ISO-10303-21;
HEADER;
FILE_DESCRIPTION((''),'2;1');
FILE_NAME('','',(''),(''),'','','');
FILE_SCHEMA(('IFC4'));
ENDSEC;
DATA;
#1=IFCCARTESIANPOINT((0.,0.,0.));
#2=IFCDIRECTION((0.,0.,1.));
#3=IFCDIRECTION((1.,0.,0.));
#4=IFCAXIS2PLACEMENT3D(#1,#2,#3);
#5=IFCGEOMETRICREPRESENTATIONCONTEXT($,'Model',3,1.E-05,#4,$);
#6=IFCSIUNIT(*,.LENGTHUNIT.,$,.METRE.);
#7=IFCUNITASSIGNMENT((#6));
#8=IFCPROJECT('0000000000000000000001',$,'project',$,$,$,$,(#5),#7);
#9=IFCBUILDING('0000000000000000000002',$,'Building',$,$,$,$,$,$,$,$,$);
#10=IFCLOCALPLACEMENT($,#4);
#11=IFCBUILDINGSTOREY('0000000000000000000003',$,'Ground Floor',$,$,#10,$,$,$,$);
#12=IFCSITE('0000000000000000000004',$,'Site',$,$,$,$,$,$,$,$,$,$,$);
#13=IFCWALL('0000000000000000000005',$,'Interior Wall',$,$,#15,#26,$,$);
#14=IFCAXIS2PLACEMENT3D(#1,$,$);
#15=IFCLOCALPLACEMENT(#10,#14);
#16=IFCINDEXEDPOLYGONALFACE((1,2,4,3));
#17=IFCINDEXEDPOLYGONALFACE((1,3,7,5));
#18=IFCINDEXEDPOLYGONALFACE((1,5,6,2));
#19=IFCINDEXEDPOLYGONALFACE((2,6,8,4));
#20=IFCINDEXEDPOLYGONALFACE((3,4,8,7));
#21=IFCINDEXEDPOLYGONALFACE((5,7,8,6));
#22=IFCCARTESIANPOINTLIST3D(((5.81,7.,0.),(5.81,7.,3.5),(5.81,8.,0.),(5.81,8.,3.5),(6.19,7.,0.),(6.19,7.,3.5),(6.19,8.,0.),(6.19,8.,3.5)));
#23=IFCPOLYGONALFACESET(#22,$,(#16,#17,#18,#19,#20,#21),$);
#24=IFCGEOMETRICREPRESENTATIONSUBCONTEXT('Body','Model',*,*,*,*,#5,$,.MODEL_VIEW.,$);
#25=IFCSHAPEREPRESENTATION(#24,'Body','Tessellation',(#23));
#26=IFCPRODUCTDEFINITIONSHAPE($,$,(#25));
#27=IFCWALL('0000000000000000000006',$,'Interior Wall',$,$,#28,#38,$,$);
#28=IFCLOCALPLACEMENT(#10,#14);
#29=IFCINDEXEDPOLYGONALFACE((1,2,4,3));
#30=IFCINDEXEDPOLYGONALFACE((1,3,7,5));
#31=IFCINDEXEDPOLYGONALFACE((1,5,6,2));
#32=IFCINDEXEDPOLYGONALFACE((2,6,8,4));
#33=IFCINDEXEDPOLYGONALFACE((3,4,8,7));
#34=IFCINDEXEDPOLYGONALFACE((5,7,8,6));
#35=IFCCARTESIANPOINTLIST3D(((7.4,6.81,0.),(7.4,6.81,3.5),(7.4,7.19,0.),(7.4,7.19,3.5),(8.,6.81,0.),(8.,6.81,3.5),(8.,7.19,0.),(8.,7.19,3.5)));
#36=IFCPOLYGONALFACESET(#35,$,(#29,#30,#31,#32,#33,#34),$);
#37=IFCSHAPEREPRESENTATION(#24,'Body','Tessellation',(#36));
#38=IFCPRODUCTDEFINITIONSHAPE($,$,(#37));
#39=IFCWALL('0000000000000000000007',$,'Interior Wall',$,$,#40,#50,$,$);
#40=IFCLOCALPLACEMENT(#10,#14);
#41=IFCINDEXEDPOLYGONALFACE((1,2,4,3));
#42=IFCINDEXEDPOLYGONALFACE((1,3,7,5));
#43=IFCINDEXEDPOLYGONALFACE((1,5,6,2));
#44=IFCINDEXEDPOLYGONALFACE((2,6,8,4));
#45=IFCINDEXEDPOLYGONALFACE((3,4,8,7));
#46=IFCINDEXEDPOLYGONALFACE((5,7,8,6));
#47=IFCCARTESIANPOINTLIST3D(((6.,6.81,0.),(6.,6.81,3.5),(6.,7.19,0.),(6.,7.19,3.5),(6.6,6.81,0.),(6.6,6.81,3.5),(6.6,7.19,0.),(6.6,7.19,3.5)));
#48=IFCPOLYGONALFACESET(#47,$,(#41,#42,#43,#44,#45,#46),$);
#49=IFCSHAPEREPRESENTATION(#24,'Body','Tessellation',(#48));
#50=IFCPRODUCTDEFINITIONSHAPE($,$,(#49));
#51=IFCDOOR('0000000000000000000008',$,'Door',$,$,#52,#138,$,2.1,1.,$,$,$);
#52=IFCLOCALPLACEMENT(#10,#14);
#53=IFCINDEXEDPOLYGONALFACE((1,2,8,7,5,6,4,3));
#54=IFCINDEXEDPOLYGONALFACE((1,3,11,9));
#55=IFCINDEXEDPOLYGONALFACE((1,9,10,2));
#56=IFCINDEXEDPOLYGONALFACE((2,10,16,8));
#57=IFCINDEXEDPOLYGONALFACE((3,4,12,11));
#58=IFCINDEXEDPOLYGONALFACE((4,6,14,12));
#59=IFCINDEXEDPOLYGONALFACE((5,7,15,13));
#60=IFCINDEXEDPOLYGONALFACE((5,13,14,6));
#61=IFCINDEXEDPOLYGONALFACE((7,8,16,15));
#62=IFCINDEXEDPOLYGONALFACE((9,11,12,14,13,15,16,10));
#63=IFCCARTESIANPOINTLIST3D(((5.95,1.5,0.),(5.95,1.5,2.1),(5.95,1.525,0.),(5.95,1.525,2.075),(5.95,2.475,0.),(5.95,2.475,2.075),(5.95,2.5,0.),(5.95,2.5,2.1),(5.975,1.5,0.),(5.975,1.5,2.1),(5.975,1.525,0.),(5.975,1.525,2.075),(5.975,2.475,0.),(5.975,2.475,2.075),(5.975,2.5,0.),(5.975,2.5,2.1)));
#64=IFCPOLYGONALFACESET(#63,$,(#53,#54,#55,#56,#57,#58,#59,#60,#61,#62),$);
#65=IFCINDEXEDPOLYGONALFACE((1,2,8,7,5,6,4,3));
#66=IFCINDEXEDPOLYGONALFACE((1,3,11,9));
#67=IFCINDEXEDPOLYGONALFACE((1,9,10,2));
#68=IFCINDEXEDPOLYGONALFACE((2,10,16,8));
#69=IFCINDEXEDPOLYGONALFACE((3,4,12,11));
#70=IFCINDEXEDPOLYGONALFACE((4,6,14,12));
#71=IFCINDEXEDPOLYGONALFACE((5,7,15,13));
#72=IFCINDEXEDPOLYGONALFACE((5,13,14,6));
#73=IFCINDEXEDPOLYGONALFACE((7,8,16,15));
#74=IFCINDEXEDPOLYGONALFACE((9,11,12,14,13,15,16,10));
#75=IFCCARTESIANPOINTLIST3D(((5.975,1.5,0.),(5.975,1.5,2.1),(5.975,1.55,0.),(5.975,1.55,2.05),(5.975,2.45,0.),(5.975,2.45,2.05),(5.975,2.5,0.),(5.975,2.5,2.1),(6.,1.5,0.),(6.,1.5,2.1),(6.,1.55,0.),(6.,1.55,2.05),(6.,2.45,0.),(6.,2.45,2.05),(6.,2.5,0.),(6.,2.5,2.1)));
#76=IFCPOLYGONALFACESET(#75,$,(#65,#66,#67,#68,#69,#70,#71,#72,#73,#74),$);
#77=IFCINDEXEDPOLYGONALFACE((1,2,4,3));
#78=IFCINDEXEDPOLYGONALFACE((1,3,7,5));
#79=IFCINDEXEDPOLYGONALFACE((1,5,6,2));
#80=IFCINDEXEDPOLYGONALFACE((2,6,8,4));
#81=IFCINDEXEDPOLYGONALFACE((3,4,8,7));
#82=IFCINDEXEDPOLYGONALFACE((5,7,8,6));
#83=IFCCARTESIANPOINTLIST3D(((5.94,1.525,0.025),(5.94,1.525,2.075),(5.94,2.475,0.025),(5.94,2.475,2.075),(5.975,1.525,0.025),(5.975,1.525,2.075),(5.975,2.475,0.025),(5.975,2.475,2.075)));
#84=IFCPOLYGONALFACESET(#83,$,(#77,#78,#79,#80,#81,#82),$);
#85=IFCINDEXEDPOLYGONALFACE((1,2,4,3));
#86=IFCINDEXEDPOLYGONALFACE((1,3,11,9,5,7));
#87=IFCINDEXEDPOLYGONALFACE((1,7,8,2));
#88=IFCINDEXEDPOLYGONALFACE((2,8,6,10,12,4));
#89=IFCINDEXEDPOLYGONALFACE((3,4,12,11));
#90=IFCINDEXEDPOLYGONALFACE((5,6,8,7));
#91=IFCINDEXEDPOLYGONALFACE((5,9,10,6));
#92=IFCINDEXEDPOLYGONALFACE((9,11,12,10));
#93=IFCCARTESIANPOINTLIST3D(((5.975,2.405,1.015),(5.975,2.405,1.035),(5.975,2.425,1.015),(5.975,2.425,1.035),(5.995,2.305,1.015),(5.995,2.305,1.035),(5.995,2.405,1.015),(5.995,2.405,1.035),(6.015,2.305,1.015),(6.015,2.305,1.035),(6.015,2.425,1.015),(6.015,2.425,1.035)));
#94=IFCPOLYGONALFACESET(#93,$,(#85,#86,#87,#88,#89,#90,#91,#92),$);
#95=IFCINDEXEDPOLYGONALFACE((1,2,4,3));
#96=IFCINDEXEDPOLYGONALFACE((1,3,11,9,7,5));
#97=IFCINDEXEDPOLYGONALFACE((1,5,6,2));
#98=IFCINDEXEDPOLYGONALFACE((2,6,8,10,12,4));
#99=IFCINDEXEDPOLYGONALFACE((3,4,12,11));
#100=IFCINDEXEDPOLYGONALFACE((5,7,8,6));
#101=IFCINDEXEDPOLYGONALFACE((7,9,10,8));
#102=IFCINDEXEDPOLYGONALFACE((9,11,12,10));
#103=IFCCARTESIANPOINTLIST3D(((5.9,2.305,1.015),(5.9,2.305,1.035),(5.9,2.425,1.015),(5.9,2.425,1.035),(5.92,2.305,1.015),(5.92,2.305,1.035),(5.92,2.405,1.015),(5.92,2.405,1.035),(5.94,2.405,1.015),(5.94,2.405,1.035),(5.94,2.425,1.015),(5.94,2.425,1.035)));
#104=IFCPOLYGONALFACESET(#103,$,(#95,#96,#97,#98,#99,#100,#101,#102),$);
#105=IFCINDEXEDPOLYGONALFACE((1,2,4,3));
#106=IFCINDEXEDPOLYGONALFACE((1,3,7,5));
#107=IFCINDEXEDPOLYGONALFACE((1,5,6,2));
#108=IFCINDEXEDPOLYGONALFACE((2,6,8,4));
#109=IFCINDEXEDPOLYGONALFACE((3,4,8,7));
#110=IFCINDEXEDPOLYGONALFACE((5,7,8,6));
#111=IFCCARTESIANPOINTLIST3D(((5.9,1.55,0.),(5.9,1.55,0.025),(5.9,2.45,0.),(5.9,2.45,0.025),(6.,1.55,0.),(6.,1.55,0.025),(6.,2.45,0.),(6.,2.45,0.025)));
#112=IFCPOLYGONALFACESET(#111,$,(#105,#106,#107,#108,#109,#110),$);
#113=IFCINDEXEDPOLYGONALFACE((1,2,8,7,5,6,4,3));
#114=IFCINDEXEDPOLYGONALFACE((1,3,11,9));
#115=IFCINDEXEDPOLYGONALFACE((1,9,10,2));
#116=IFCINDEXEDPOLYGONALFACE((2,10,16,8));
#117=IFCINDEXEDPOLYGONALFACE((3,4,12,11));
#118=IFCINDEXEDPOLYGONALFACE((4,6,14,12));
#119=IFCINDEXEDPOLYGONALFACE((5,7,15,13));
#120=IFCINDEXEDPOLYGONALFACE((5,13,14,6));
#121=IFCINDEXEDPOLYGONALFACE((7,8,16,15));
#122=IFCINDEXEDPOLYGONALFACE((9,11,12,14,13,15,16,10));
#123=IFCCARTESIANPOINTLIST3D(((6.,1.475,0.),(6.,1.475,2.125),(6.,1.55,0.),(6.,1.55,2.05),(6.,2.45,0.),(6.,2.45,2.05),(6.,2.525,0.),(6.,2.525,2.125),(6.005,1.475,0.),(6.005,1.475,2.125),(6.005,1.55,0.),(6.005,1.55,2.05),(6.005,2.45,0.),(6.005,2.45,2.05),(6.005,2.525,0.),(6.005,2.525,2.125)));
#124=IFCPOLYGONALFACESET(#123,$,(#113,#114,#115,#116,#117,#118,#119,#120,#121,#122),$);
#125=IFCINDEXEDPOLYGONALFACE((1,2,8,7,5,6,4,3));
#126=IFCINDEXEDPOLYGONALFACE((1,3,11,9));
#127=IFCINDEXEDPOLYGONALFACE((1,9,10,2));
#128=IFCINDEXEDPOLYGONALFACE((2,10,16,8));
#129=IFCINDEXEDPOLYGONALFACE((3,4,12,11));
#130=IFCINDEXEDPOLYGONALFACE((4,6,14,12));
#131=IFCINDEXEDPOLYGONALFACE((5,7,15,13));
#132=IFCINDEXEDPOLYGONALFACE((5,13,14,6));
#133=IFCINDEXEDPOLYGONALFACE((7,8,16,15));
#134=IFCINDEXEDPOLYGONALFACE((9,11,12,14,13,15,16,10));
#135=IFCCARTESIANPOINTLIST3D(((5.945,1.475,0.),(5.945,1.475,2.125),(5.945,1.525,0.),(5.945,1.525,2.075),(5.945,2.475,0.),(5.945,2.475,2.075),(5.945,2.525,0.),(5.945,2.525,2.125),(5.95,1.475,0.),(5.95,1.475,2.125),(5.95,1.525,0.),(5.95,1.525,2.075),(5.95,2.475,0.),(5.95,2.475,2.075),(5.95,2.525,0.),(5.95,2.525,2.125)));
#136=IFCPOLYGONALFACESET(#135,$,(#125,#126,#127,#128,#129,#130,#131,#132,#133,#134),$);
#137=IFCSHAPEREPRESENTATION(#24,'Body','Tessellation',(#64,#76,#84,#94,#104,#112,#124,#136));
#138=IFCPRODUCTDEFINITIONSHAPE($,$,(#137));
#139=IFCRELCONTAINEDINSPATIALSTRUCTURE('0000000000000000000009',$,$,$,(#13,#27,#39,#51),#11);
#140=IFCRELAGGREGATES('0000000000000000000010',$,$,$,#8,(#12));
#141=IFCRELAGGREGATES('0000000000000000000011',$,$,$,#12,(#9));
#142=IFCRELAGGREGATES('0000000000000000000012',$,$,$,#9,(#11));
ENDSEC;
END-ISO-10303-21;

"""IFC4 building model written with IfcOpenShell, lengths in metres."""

from ifc_helpers import new_model, si_unit, frame, origin_with_axes, place, context, subcontext, project, spatial, line, indexed_curve, outline, extrude, element, save


model = new_model("IFC4")

# Units and contexts
model_context = context("Model", 3, precision=1e-05, world=origin_with_axes())
body_context = subcontext(model_context, "Body", "Model", "MODEL_VIEW")
ifc_project = project(units=[si_unit("LENGTHUNIT", "METRE")], contexts=[model_context])

# Site, building, storey
site = spatial("IfcSite", under=ifc_project, Name="Site")
building = spatial("IfcBuilding", under=site, Name="Building")
storey_placement = place(None, origin_with_axes())
storey = spatial("IfcBuildingStorey", under=building, at=storey_placement, Name="Ground Floor")

# Walls
wall_1_placement = place(storey_placement, frame((6.0, 7.0, 0.0), z_axis=(0.0, 0.0, 1.0), x_axis=(0.0, 1.0, 0.0)))
element("IfcWall", 1, at=wall_1_placement, inside=storey, Name="Interior Wall", context=body_context, shape_type="SweptSolid", body=[
    extrude(outline(indexed_curve([(0.0, 0.0), (0.0, 0.38), (1.0, 0.38), (1.0, 0.0), (0.0, 0.0)], self_intersect=False)), frame((0.0, -0.19, 0.0), z_axis=(0.0, 0.0, 1.0), x_axis=(1.0, 0.0, 0.0)), (0.0, 0.0, 1.0), 3.5),
])
for number, where, z_axis, x_axis, name in (
    (2, (8.0, 7.0, 0.0), (0.0, 0.0, 1.0), (-1.0, 0.0, 0.0), "Interior Wall"),
    (3, (6.6, 7.0, 0.0), (0.0, 0.0, 1.0), (-1.0, 0.0, 0.0), "Interior Wall"),
):
    element("IfcWall", number, at=place(storey_placement, frame(where, z_axis=z_axis, x_axis=x_axis)), inside=storey, Name=name, context=body_context, shape_type="SweptSolid", body=[
        extrude(outline(indexed_curve([(0.0, 0.0), (0.0, 0.38), (0.6, 0.38), (0.6, 0.0), (0.0, 0.0)], self_intersect=False)), frame((0.0, -0.19, 0.0), z_axis=(0.0, 0.0, 1.0), x_axis=(1.0, 0.0, 0.0)), (0.0, 0.0, 1.0), 3.5),
    ])

# Door
door_1_placement = place(storey_placement, frame((6.0, 1.5, 0.0), z_axis=(0.0, 0.0, 1.0), x_axis=(0.0, 1.0, 0.0)))
element("IfcDoor", 4, at=door_1_placement, inside=storey, Name="Door", OverallHeight=2.1, OverallWidth=1.0, context=body_context, shape_type="SweptSolid", body=[
    extrude(outline(indexed_curve([(0.0, 0.0), (0.0, 2.1), (1.0, 2.1), (1.0, 0.0), (0.975, 0.0), (0.975, 2.075), (0.025, 2.075), (0.025, 0.0)], segments=[line(1, 2, 3, 4, 5, 6, 7, 8, 1)])), frame((0.0, 0.025, 0.0), z_axis=(0.0, -1.0, 0.0), x_axis=(1.0, 0.0, 0.0)), (0.0, 0.0, -1.0), 0.025),
    extrude(outline(indexed_curve([(0.0, 0.0), (0.0, 2.1), (1.0, 2.1), (1.0, 0.0), (0.95, 0.0), (0.95, 2.05), (0.05, 2.05), (0.05, 0.0)], segments=[line(1, 2, 3, 4, 5, 6, 7, 8, 1)])), frame((0.0, 0.0, 0.0), z_axis=(0.0, -1.0, 0.0), x_axis=(1.0, 0.0, 0.0)), (0.0, 0.0, -1.0), 0.025),
    extrude(outline(indexed_curve([(0.0, 0.0), (0.95, 0.0), (0.95, 0.035), (0.0, 0.035)], segments=[line(1, 2, 3, 4, 1)])), frame((0.025, 0.025, 0.025), z_axis=(0.0, 0.0, 1.0), x_axis=(1.0, 0.0, 0.0)), (0.0, 0.0, 1.0), 2.05),
    extrude(outline(indexed_curve([(0.0, 0.0), (0.0, -0.04), (-0.12, -0.04), (-0.12, -0.02), (-0.02, -0.02), (-0.02, 0.0)], segments=[line(1, 2, 3, 4, 5, 6, 1)])), frame((0.925, 0.025, 1.015), z_axis=(0.0, 0.0, 1.0), x_axis=(1.0, 0.0, 0.0)), (0.0, 0.0, 1.0), 0.02),
    extrude(outline(indexed_curve([(0.0, 0.0), (0.0, 0.04), (-0.12, 0.04), (-0.12, 0.02), (-0.02, 0.02), (-0.02, 0.0)], segments=[line(1, 2, 3, 4, 5, 6, 1)])), frame((0.925, 0.06, 1.015), z_axis=(0.0, 0.0, 1.0), x_axis=(1.0, 0.0, 0.0)), (0.0, 0.0, 1.0), 0.02),
    extrude(outline(indexed_curve([(0.0, 0.0), (0.9, 0.0), (0.9, 0.1), (0.0, 0.1)], segments=[line(1, 2, 3, 4, 1)])), frame((0.05, 0.0, 0.0), z_axis=(0.0, 0.0, 1.0), x_axis=(1.0, 0.0, 0.0)), (0.0, 0.0, 1.0), 0.025),
    extrude(outline(indexed_curve([(0.0, 0.0), (0.0, 2.125), (1.05, 2.125), (1.05, 0.0), (0.975, 0.0), (0.975, 2.05), (0.075, 2.05), (0.075, 0.0)], segments=[line(1, 2, 3, 4, 5, 6, 7, 8, 1)])), frame((-0.025, -0.005, 0.0), z_axis=(0.0, -1.0, 0.0), x_axis=(1.0, 0.0, 0.0)), (0.0, 0.0, -1.0), 0.005),
    extrude(outline(indexed_curve([(0.0, 0.0), (0.0, 2.125), (1.05, 2.125), (1.05, 0.0), (1.0, 0.0), (1.0, 2.075), (0.05, 2.075), (0.05, 0.0)], segments=[line(1, 2, 3, 4, 5, 6, 7, 8, 1)])), frame((-0.025, 0.05, 0.0), z_axis=(0.0, -1.0, 0.0), x_axis=(1.0, 0.0, 0.0)), (0.0, 0.0, -1.0), 0.005),
])

save(model, "model.ifc")
